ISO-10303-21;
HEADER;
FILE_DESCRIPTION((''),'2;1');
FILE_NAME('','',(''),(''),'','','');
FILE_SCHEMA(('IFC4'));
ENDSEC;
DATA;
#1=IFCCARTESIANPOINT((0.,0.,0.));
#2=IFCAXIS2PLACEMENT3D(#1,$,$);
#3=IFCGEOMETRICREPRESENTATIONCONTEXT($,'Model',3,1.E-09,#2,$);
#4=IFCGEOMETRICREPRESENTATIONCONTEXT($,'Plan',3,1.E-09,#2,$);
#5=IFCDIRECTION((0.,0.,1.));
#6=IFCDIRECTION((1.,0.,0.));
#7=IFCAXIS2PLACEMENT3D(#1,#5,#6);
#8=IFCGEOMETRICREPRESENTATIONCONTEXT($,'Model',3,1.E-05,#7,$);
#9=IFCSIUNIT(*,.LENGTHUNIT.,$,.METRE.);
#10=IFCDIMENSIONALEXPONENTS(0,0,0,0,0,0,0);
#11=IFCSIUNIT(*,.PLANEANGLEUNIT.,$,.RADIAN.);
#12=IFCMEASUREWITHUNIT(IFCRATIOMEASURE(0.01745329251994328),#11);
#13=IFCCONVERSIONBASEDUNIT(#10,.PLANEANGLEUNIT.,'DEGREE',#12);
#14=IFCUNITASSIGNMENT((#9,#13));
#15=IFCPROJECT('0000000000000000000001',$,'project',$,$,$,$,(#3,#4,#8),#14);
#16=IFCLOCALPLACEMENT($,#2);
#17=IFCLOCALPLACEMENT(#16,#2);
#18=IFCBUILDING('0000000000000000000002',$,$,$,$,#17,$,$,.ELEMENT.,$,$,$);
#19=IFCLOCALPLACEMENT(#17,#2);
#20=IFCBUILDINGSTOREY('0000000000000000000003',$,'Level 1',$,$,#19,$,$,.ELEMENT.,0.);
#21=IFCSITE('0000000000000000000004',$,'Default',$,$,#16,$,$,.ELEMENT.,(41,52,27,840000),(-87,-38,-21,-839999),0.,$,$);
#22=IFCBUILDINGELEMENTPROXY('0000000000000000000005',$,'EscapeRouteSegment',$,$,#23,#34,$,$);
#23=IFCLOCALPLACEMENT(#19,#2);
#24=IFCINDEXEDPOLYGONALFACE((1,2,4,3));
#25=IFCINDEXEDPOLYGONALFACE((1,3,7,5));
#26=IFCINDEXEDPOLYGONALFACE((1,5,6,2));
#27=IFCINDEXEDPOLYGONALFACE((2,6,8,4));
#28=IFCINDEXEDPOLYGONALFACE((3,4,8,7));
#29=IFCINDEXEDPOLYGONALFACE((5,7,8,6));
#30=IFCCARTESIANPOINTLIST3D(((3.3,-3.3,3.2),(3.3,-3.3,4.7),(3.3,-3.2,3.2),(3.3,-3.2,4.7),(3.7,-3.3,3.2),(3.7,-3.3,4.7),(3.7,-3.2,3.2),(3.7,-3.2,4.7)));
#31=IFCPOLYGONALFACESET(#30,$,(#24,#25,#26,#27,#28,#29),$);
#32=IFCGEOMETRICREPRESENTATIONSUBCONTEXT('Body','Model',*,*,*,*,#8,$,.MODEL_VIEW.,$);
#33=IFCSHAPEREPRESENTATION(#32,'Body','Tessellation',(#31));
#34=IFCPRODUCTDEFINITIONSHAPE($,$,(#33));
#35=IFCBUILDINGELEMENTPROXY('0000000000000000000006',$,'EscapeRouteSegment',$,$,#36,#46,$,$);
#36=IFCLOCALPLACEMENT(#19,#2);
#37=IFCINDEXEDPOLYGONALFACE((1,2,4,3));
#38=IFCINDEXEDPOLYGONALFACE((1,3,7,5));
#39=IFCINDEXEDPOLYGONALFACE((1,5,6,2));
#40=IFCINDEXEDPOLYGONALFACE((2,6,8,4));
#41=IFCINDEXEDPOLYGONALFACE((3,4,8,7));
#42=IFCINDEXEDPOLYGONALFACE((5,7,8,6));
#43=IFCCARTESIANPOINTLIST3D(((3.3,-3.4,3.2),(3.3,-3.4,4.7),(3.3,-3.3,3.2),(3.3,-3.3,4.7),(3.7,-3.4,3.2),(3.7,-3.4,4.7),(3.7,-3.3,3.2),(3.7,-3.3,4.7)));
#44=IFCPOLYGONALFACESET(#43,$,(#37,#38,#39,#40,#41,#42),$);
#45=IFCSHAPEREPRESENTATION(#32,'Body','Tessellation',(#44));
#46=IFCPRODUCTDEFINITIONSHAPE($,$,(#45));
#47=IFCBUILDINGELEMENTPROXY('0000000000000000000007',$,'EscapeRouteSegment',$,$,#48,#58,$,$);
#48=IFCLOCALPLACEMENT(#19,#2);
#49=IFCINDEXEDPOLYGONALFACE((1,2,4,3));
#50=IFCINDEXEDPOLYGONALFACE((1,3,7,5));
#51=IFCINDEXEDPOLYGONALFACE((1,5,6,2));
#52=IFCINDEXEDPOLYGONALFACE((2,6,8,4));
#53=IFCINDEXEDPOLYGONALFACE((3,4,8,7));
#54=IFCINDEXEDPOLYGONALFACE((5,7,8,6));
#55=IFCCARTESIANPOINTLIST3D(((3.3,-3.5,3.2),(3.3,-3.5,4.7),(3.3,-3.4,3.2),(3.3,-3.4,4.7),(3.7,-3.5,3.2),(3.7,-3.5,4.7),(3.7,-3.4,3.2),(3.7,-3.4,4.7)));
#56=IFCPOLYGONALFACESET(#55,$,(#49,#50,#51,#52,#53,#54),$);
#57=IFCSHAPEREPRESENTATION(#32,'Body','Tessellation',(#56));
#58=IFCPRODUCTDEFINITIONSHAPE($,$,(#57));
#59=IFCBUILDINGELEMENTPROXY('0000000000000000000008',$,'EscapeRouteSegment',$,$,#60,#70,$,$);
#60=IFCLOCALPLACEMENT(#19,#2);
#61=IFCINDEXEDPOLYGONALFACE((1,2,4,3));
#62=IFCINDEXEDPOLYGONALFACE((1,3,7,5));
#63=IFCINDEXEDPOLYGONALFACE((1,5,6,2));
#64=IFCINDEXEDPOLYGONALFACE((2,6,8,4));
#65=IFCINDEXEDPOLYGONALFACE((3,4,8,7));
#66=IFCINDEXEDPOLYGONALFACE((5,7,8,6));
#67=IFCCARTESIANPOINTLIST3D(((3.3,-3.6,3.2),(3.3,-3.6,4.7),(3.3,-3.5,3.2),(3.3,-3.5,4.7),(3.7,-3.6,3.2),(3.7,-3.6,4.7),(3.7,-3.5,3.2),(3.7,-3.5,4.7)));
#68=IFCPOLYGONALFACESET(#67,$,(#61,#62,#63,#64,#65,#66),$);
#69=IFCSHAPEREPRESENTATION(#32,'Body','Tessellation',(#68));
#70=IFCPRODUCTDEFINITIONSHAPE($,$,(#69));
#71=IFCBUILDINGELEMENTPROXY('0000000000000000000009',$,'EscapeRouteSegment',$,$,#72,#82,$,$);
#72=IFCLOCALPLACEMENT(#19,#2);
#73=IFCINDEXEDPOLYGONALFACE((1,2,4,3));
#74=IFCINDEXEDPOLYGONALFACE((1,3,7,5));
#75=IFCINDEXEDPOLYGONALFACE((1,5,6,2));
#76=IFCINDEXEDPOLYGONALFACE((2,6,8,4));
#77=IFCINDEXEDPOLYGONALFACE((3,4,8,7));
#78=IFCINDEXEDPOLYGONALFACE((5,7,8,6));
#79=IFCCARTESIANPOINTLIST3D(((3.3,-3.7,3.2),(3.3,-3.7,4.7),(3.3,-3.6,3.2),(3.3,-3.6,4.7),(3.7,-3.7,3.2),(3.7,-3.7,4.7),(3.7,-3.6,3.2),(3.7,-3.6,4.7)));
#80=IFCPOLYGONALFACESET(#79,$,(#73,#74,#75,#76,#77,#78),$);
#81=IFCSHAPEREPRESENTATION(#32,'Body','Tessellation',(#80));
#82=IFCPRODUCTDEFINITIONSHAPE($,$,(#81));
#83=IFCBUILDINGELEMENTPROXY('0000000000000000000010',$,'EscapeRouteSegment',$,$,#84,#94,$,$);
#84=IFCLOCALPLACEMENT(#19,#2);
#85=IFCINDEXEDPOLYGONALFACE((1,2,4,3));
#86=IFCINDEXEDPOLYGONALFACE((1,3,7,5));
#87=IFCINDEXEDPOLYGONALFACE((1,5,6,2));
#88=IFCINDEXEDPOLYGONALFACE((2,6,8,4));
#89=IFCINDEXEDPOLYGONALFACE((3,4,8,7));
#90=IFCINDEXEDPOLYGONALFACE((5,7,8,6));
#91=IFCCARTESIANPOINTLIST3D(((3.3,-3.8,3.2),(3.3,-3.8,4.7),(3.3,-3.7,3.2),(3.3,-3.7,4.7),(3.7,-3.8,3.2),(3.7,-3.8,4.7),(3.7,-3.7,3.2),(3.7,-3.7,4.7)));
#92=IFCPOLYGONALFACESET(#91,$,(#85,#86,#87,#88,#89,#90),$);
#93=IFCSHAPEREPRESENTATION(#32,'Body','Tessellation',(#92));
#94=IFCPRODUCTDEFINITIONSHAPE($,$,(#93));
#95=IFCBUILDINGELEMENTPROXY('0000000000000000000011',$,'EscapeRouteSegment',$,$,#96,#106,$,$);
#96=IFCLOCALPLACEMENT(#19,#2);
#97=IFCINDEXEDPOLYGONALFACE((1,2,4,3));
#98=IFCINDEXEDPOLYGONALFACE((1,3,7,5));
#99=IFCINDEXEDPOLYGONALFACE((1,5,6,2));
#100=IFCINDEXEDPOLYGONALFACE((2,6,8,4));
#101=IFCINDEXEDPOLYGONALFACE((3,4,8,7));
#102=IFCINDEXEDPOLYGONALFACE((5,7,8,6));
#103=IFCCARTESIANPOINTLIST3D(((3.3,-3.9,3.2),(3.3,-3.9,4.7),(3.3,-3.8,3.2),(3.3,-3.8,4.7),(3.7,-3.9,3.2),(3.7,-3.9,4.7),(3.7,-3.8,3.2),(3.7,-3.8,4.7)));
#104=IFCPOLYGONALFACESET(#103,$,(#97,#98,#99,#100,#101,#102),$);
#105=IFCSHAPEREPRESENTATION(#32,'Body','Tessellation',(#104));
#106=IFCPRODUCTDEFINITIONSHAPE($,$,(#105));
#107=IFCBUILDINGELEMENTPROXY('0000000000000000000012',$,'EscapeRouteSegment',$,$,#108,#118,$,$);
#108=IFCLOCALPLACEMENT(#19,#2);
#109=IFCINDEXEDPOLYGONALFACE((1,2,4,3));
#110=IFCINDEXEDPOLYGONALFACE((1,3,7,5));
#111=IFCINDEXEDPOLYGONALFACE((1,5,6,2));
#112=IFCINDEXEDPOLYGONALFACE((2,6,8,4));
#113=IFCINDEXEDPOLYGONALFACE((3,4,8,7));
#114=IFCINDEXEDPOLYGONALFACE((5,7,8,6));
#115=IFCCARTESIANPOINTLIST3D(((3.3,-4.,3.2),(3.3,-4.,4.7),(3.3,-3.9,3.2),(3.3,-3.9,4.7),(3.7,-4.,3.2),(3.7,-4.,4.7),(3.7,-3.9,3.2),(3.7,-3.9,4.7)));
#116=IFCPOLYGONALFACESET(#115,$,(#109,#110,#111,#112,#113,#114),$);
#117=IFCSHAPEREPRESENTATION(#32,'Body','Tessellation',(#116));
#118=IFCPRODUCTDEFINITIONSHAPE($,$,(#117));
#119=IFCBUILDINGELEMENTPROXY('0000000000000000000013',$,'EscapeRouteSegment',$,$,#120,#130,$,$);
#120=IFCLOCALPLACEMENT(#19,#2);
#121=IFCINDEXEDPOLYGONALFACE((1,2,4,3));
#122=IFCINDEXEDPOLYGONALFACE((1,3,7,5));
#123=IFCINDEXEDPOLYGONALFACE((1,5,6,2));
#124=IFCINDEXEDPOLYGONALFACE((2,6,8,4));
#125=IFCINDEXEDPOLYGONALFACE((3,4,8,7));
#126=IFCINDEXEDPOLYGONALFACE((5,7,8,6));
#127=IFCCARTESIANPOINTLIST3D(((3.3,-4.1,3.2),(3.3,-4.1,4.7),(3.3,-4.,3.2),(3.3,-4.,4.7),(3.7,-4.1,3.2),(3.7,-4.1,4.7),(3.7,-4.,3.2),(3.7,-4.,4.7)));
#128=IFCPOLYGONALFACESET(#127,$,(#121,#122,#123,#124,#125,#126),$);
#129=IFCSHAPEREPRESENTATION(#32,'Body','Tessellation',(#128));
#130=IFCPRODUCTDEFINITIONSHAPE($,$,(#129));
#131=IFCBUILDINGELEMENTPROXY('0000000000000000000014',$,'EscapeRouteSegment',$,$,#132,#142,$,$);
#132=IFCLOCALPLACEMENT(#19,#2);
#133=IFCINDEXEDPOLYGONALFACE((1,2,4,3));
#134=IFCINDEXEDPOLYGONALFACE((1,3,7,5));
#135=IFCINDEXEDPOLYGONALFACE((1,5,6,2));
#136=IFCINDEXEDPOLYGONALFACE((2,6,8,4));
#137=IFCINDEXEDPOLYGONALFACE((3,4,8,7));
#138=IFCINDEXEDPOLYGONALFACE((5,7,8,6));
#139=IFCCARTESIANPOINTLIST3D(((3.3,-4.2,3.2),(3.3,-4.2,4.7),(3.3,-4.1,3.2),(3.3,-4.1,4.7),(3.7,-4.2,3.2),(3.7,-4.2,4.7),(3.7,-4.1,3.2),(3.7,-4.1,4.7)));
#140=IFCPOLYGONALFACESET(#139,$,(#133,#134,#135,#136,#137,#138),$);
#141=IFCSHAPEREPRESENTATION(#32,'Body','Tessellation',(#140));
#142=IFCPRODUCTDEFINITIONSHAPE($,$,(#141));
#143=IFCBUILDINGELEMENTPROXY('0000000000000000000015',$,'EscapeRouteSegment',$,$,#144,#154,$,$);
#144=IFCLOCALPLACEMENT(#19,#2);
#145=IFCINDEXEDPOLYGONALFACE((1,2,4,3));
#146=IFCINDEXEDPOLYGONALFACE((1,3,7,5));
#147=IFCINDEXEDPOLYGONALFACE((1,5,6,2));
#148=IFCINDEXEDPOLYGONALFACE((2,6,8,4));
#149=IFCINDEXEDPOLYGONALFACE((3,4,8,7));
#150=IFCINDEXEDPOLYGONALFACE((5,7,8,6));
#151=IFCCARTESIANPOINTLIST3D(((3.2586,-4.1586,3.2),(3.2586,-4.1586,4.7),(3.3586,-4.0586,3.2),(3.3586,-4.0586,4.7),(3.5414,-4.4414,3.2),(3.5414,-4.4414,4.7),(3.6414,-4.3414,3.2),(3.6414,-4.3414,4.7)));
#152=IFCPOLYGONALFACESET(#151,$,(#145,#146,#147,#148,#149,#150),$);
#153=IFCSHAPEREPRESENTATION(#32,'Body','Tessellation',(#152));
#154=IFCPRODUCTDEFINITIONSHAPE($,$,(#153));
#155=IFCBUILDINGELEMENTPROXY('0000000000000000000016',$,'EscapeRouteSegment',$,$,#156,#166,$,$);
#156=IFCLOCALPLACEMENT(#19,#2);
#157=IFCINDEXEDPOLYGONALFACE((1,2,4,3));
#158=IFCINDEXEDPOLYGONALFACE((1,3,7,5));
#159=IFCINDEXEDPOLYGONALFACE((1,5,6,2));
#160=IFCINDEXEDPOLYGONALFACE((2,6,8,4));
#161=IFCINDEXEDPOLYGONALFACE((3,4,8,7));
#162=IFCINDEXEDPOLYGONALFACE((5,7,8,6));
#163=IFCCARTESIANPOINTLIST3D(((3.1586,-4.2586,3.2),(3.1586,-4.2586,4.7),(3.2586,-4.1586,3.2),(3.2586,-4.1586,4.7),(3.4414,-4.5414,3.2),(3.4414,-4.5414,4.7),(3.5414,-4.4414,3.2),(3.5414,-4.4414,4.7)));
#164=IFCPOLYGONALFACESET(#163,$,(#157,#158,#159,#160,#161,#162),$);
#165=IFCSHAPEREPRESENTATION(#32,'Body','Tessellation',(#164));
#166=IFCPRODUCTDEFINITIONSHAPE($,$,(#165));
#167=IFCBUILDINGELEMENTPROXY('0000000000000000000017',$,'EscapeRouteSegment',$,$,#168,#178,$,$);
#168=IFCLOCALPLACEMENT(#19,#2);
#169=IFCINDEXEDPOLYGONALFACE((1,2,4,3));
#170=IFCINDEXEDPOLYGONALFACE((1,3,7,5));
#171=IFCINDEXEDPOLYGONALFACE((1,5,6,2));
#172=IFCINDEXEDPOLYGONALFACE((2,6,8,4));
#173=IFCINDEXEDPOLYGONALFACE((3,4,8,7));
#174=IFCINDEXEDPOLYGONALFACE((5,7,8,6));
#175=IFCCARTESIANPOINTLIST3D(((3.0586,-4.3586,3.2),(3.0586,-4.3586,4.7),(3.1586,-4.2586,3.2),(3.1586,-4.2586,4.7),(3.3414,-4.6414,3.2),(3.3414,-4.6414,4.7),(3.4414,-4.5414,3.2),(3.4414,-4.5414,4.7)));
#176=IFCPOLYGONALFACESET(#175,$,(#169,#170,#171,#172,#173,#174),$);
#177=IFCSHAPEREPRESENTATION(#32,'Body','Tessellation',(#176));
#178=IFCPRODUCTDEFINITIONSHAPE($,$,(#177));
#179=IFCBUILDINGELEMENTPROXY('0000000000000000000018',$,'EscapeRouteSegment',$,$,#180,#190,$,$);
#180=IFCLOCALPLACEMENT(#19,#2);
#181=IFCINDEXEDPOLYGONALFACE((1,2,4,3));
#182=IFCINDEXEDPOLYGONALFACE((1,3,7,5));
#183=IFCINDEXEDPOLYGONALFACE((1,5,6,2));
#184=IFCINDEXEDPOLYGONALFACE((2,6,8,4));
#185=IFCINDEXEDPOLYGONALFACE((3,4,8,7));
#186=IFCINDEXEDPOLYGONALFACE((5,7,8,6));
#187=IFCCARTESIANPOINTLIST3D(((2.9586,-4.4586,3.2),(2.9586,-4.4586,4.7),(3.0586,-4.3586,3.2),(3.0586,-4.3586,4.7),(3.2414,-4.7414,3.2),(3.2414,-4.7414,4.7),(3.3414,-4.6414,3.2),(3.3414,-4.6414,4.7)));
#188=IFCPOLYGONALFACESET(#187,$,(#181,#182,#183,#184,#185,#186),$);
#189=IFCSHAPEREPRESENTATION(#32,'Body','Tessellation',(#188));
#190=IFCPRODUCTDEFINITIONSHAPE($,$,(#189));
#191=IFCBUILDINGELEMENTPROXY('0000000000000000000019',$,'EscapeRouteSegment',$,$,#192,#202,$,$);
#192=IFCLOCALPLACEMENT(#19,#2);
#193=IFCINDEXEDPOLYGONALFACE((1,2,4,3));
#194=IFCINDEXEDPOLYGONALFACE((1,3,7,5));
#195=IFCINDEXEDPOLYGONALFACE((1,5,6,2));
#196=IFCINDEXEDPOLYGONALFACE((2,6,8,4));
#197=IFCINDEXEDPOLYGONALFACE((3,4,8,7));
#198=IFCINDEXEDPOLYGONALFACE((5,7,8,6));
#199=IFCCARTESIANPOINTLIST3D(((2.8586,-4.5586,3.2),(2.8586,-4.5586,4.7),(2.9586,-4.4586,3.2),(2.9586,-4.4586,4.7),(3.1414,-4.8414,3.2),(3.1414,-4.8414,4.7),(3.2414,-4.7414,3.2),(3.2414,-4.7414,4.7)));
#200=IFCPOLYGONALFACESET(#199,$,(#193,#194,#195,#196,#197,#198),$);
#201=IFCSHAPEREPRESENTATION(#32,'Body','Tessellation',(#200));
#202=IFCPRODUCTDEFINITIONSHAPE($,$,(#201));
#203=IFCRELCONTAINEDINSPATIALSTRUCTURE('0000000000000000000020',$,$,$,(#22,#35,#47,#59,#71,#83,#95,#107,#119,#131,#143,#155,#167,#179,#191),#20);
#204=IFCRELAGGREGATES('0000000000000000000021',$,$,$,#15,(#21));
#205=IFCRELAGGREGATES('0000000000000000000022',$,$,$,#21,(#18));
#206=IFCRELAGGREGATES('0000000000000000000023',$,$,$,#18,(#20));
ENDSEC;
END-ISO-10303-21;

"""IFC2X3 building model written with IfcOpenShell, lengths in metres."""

from ifc_helpers import new_model, entity, si_unit, converted_unit, frame, origin, origin_with_axes, place, context, subcontext, project, spatial, polyline, outline, extrude, element, save


model = new_model("IFC2X3")

# Units and contexts
model_context_1 = context("Model", 3, precision=1e-09, world=origin())
plan_context = context("Plan", 3, precision=1e-09, world=origin())
model_context_2 = context("Model", 3, precision=1e-05, world=origin_with_axes())
body_context = subcontext(model_context_2, "Body", "Model", "MODEL_VIEW")
ifc_project = project(units=[si_unit("LENGTHUNIT", "METRE"), converted_unit("PLANEANGLEUNIT", "DEGREE", entity("IfcRatioMeasure", 0.01745329251994328), si_unit("PLANEANGLEUNIT", "RADIAN"), dimensions=[0, 0, 0, 0, 0, 0, 0])], contexts=[model_context_1, plan_context, model_context_2])

# Site, building, storey
site_placement = place(None, origin())
site = spatial("IfcSite", under=ifc_project, at=site_placement, Name="Default", CompositionType="ELEMENT", RefLatitude=(41, 52, 27, 840000), RefLongitude=(-87, -38, -21, -839999), RefElevation=0.0)
building_placement = place(site_placement, origin())
building = spatial("IfcBuilding", under=site, at=building_placement, CompositionType="ELEMENT")
storey_placement = place(building_placement, origin())
storey = spatial("IfcBuildingStorey", under=building, at=storey_placement, Name="Level 1", CompositionType="ELEMENT", Elevation=0.0)

# Building element proxies
proxy_1_placement = place(storey_placement, frame((3.5, -3.2, 3.2), z_axis=(0.0, 0.0, 1.0), x_axis=(0.0, -1.0, 0.0)))
element("IfcBuildingElementProxy", 1, at=proxy_1_placement, inside=storey, Name="EscapeRouteSegment", context=body_context, shape_type="SweptSolid", body=[
    extrude(outline(polyline([(0.0, -0.2), (0.0, 0.2), (0.1, 0.2), (0.1, -0.2), (0.0, -0.2)])), origin_with_axes(), (0.0, 0.0, 1.0), 1.5),
])
proxy_2_placement = place(storey_placement, frame((3.5, -3.3, 3.2), z_axis=(0.0, 0.0, 1.0), x_axis=(0.0, -1.0, 0.0)))
element("IfcBuildingElementProxy", 2, at=proxy_2_placement, inside=storey, Name="EscapeRouteSegment", context=body_context, shape_type="SweptSolid", body=[
    extrude(outline(polyline([(0.0, -0.2), (0.0, 0.2), (0.1, 0.2), (0.1, -0.2), (0.0, -0.2)])), origin_with_axes(), (0.0, 0.0, 1.0), 1.5),
])
for number, where, z_axis, x_axis, name in (
    (3, (3.5, -3.4, 3.2), (0.0, 0.0, 1.0), (0.0, -1.0, 0.0), "EscapeRouteSegment"),
    (4, (3.5, -3.5, 3.2), (0.0, 0.0, 1.0), (0.0, -1.0, 0.0), "EscapeRouteSegment"),
):
    element("IfcBuildingElementProxy", number, at=place(storey_placement, frame(where, z_axis=z_axis, x_axis=x_axis)), inside=storey, Name=name, context=body_context, shape_type="SweptSolid", body=[
        extrude(outline(polyline([(0.0, -0.2), (0.0, 0.2), (0.1, 0.2), (0.1, -0.2), (0.0, -0.2)])), origin_with_axes(), (0.0, 0.0, 1.0), 1.5),
    ])
proxy_3_placement = place(storey_placement, frame((3.5, -3.6, 3.2), z_axis=(0.0, 0.0, 1.0), x_axis=(0.0, -1.0, 0.0)))
element("IfcBuildingElementProxy", 5, at=proxy_3_placement, inside=storey, Name="EscapeRouteSegment", context=body_context, shape_type="SweptSolid", body=[
    extrude(outline(polyline([(0.0, -0.2), (0.0, 0.2), (0.1, 0.2), (0.1, -0.2), (0.0, -0.2)])), origin_with_axes(), (0.0, 0.0, 1.0), 1.5),
])
proxy_4_placement = place(storey_placement, frame((3.5, -3.7, 3.2), z_axis=(0.0, 0.0, 1.0), x_axis=(0.0, -1.0, 0.0)))
element("IfcBuildingElementProxy", 6, at=proxy_4_placement, inside=storey, Name="EscapeRouteSegment", context=body_context, shape_type="SweptSolid", body=[
    extrude(outline(polyline([(0.0, -0.2), (0.0, 0.2), (0.1, 0.2), (0.1, -0.2), (0.0, -0.2)])), origin_with_axes(), (0.0, 0.0, 1.0), 1.5),
])
proxy_5_placement = place(storey_placement, frame((3.5, -3.8, 3.2), z_axis=(0.0, 0.0, 1.0), x_axis=(0.0, -1.0, 0.0)))
element("IfcBuildingElementProxy", 7, at=proxy_5_placement, inside=storey, Name="EscapeRouteSegment", context=body_context, shape_type="SweptSolid", body=[
    extrude(outline(polyline([(0.0, -0.2), (0.0, 0.2), (0.1, 0.2), (0.1, -0.2), (0.0, -0.2)])), origin_with_axes(), (0.0, 0.0, 1.0), 1.5),
])
for number, where, z_axis, x_axis, name in (
    (8, (3.5, -3.9, 3.2), (0.0, 0.0, 1.0), (0.0, -1.0, 0.0), "EscapeRouteSegment"),
    (9, (3.5, -4.0, 3.2), (0.0, 0.0, 1.0), (0.0, -1.0, 0.0), "EscapeRouteSegment"),
    (10, (3.5, -4.1, 3.2), (0.0, 0.0, 1.0), (0.0, -1.0, 0.0), "EscapeRouteSegment"),
):
    element("IfcBuildingElementProxy", number, at=place(storey_placement, frame(where, z_axis=z_axis, x_axis=x_axis)), inside=storey, Name=name, context=body_context, shape_type="SweptSolid", body=[
        extrude(outline(polyline([(0.0, -0.2), (0.0, 0.2), (0.1, 0.2), (0.1, -0.2), (0.0, -0.2)])), origin_with_axes(), (0.0, 0.0, 1.0), 1.5),
    ])
proxy_6_placement = place(storey_placement, frame((3.5, -4.2, 3.2), z_axis=(0.0, 0.0, 1.0), x_axis=(-0.707105, -0.707108, 0.0)))
element("IfcBuildingElementProxy", 11, at=proxy_6_placement, inside=storey, Name="EscapeRouteSegment", context=body_context, shape_type="SweptSolid", body=[
    extrude(outline(polyline([(0.0, -0.2), (0.0, 0.2), (0.1414, 0.2), (0.1414, -0.2), (0.0, -0.2)])), origin_with_axes(), (0.0, 0.0, 1.0), 1.5),
])
proxy_7_placement = place(storey_placement, frame((3.4, -4.3, 3.2), z_axis=(0.0, 0.0, 1.0), x_axis=(-0.707108, -0.707106, 0.0)))
element("IfcBuildingElementProxy", 12, at=proxy_7_placement, inside=storey, Name="EscapeRouteSegment", context=body_context, shape_type="SweptSolid", body=[
    extrude(outline(polyline([(0.0, -0.2), (0.0, 0.2), (0.1414, 0.2), (0.1414, -0.2), (0.0, -0.2)])), origin_with_axes(), (0.0, 0.0, 1.0), 1.5),
])
proxy_8_placement = place(storey_placement, frame((3.3, -4.4, 3.2), z_axis=(0.0, 0.0, 1.0), x_axis=(-0.707107, -0.707107, 0.0)))
element("IfcBuildingElementProxy", 13, at=proxy_8_placement, inside=storey, Name="EscapeRouteSegment", context=body_context, shape_type="SweptSolid", body=[
    extrude(outline(polyline([(0.0, -0.2), (0.0, 0.2), (0.1414, 0.2), (0.1414, -0.2), (0.0, -0.2)])), origin_with_axes(), (0.0, 0.0, 1.0), 1.5),
])
proxy_9_placement = place(storey_placement, frame((3.2, -4.5, 3.2), z_axis=(0.0, 0.0, 1.0), x_axis=(-0.707108, -0.707106, 0.0)))
element("IfcBuildingElementProxy", 14, at=proxy_9_placement, inside=storey, Name="EscapeRouteSegment", context=body_context, shape_type="SweptSolid", body=[
    extrude(outline(polyline([(0.0, -0.2), (0.0, 0.2), (0.1414, 0.2), (0.1414, -0.2), (0.0, -0.2)])), origin_with_axes(), (0.0, 0.0, 1.0), 1.5),
])
proxy_10_placement = place(storey_placement, frame((3.1, -4.6, 3.2), z_axis=(0.0, 0.0, 1.0), x_axis=(-0.707107, -0.707107, 0.0)))
element("IfcBuildingElementProxy", 15, at=proxy_10_placement, inside=storey, Name="EscapeRouteSegment", context=body_context, shape_type="SweptSolid", body=[
    extrude(outline(polyline([(0.0, -0.2), (0.0, 0.2), (0.1414, 0.2), (0.1414, -0.2), (0.0, -0.2)])), origin_with_axes(), (0.0, 0.0, 1.0), 1.5),
])

save(model, "model.ifc")
